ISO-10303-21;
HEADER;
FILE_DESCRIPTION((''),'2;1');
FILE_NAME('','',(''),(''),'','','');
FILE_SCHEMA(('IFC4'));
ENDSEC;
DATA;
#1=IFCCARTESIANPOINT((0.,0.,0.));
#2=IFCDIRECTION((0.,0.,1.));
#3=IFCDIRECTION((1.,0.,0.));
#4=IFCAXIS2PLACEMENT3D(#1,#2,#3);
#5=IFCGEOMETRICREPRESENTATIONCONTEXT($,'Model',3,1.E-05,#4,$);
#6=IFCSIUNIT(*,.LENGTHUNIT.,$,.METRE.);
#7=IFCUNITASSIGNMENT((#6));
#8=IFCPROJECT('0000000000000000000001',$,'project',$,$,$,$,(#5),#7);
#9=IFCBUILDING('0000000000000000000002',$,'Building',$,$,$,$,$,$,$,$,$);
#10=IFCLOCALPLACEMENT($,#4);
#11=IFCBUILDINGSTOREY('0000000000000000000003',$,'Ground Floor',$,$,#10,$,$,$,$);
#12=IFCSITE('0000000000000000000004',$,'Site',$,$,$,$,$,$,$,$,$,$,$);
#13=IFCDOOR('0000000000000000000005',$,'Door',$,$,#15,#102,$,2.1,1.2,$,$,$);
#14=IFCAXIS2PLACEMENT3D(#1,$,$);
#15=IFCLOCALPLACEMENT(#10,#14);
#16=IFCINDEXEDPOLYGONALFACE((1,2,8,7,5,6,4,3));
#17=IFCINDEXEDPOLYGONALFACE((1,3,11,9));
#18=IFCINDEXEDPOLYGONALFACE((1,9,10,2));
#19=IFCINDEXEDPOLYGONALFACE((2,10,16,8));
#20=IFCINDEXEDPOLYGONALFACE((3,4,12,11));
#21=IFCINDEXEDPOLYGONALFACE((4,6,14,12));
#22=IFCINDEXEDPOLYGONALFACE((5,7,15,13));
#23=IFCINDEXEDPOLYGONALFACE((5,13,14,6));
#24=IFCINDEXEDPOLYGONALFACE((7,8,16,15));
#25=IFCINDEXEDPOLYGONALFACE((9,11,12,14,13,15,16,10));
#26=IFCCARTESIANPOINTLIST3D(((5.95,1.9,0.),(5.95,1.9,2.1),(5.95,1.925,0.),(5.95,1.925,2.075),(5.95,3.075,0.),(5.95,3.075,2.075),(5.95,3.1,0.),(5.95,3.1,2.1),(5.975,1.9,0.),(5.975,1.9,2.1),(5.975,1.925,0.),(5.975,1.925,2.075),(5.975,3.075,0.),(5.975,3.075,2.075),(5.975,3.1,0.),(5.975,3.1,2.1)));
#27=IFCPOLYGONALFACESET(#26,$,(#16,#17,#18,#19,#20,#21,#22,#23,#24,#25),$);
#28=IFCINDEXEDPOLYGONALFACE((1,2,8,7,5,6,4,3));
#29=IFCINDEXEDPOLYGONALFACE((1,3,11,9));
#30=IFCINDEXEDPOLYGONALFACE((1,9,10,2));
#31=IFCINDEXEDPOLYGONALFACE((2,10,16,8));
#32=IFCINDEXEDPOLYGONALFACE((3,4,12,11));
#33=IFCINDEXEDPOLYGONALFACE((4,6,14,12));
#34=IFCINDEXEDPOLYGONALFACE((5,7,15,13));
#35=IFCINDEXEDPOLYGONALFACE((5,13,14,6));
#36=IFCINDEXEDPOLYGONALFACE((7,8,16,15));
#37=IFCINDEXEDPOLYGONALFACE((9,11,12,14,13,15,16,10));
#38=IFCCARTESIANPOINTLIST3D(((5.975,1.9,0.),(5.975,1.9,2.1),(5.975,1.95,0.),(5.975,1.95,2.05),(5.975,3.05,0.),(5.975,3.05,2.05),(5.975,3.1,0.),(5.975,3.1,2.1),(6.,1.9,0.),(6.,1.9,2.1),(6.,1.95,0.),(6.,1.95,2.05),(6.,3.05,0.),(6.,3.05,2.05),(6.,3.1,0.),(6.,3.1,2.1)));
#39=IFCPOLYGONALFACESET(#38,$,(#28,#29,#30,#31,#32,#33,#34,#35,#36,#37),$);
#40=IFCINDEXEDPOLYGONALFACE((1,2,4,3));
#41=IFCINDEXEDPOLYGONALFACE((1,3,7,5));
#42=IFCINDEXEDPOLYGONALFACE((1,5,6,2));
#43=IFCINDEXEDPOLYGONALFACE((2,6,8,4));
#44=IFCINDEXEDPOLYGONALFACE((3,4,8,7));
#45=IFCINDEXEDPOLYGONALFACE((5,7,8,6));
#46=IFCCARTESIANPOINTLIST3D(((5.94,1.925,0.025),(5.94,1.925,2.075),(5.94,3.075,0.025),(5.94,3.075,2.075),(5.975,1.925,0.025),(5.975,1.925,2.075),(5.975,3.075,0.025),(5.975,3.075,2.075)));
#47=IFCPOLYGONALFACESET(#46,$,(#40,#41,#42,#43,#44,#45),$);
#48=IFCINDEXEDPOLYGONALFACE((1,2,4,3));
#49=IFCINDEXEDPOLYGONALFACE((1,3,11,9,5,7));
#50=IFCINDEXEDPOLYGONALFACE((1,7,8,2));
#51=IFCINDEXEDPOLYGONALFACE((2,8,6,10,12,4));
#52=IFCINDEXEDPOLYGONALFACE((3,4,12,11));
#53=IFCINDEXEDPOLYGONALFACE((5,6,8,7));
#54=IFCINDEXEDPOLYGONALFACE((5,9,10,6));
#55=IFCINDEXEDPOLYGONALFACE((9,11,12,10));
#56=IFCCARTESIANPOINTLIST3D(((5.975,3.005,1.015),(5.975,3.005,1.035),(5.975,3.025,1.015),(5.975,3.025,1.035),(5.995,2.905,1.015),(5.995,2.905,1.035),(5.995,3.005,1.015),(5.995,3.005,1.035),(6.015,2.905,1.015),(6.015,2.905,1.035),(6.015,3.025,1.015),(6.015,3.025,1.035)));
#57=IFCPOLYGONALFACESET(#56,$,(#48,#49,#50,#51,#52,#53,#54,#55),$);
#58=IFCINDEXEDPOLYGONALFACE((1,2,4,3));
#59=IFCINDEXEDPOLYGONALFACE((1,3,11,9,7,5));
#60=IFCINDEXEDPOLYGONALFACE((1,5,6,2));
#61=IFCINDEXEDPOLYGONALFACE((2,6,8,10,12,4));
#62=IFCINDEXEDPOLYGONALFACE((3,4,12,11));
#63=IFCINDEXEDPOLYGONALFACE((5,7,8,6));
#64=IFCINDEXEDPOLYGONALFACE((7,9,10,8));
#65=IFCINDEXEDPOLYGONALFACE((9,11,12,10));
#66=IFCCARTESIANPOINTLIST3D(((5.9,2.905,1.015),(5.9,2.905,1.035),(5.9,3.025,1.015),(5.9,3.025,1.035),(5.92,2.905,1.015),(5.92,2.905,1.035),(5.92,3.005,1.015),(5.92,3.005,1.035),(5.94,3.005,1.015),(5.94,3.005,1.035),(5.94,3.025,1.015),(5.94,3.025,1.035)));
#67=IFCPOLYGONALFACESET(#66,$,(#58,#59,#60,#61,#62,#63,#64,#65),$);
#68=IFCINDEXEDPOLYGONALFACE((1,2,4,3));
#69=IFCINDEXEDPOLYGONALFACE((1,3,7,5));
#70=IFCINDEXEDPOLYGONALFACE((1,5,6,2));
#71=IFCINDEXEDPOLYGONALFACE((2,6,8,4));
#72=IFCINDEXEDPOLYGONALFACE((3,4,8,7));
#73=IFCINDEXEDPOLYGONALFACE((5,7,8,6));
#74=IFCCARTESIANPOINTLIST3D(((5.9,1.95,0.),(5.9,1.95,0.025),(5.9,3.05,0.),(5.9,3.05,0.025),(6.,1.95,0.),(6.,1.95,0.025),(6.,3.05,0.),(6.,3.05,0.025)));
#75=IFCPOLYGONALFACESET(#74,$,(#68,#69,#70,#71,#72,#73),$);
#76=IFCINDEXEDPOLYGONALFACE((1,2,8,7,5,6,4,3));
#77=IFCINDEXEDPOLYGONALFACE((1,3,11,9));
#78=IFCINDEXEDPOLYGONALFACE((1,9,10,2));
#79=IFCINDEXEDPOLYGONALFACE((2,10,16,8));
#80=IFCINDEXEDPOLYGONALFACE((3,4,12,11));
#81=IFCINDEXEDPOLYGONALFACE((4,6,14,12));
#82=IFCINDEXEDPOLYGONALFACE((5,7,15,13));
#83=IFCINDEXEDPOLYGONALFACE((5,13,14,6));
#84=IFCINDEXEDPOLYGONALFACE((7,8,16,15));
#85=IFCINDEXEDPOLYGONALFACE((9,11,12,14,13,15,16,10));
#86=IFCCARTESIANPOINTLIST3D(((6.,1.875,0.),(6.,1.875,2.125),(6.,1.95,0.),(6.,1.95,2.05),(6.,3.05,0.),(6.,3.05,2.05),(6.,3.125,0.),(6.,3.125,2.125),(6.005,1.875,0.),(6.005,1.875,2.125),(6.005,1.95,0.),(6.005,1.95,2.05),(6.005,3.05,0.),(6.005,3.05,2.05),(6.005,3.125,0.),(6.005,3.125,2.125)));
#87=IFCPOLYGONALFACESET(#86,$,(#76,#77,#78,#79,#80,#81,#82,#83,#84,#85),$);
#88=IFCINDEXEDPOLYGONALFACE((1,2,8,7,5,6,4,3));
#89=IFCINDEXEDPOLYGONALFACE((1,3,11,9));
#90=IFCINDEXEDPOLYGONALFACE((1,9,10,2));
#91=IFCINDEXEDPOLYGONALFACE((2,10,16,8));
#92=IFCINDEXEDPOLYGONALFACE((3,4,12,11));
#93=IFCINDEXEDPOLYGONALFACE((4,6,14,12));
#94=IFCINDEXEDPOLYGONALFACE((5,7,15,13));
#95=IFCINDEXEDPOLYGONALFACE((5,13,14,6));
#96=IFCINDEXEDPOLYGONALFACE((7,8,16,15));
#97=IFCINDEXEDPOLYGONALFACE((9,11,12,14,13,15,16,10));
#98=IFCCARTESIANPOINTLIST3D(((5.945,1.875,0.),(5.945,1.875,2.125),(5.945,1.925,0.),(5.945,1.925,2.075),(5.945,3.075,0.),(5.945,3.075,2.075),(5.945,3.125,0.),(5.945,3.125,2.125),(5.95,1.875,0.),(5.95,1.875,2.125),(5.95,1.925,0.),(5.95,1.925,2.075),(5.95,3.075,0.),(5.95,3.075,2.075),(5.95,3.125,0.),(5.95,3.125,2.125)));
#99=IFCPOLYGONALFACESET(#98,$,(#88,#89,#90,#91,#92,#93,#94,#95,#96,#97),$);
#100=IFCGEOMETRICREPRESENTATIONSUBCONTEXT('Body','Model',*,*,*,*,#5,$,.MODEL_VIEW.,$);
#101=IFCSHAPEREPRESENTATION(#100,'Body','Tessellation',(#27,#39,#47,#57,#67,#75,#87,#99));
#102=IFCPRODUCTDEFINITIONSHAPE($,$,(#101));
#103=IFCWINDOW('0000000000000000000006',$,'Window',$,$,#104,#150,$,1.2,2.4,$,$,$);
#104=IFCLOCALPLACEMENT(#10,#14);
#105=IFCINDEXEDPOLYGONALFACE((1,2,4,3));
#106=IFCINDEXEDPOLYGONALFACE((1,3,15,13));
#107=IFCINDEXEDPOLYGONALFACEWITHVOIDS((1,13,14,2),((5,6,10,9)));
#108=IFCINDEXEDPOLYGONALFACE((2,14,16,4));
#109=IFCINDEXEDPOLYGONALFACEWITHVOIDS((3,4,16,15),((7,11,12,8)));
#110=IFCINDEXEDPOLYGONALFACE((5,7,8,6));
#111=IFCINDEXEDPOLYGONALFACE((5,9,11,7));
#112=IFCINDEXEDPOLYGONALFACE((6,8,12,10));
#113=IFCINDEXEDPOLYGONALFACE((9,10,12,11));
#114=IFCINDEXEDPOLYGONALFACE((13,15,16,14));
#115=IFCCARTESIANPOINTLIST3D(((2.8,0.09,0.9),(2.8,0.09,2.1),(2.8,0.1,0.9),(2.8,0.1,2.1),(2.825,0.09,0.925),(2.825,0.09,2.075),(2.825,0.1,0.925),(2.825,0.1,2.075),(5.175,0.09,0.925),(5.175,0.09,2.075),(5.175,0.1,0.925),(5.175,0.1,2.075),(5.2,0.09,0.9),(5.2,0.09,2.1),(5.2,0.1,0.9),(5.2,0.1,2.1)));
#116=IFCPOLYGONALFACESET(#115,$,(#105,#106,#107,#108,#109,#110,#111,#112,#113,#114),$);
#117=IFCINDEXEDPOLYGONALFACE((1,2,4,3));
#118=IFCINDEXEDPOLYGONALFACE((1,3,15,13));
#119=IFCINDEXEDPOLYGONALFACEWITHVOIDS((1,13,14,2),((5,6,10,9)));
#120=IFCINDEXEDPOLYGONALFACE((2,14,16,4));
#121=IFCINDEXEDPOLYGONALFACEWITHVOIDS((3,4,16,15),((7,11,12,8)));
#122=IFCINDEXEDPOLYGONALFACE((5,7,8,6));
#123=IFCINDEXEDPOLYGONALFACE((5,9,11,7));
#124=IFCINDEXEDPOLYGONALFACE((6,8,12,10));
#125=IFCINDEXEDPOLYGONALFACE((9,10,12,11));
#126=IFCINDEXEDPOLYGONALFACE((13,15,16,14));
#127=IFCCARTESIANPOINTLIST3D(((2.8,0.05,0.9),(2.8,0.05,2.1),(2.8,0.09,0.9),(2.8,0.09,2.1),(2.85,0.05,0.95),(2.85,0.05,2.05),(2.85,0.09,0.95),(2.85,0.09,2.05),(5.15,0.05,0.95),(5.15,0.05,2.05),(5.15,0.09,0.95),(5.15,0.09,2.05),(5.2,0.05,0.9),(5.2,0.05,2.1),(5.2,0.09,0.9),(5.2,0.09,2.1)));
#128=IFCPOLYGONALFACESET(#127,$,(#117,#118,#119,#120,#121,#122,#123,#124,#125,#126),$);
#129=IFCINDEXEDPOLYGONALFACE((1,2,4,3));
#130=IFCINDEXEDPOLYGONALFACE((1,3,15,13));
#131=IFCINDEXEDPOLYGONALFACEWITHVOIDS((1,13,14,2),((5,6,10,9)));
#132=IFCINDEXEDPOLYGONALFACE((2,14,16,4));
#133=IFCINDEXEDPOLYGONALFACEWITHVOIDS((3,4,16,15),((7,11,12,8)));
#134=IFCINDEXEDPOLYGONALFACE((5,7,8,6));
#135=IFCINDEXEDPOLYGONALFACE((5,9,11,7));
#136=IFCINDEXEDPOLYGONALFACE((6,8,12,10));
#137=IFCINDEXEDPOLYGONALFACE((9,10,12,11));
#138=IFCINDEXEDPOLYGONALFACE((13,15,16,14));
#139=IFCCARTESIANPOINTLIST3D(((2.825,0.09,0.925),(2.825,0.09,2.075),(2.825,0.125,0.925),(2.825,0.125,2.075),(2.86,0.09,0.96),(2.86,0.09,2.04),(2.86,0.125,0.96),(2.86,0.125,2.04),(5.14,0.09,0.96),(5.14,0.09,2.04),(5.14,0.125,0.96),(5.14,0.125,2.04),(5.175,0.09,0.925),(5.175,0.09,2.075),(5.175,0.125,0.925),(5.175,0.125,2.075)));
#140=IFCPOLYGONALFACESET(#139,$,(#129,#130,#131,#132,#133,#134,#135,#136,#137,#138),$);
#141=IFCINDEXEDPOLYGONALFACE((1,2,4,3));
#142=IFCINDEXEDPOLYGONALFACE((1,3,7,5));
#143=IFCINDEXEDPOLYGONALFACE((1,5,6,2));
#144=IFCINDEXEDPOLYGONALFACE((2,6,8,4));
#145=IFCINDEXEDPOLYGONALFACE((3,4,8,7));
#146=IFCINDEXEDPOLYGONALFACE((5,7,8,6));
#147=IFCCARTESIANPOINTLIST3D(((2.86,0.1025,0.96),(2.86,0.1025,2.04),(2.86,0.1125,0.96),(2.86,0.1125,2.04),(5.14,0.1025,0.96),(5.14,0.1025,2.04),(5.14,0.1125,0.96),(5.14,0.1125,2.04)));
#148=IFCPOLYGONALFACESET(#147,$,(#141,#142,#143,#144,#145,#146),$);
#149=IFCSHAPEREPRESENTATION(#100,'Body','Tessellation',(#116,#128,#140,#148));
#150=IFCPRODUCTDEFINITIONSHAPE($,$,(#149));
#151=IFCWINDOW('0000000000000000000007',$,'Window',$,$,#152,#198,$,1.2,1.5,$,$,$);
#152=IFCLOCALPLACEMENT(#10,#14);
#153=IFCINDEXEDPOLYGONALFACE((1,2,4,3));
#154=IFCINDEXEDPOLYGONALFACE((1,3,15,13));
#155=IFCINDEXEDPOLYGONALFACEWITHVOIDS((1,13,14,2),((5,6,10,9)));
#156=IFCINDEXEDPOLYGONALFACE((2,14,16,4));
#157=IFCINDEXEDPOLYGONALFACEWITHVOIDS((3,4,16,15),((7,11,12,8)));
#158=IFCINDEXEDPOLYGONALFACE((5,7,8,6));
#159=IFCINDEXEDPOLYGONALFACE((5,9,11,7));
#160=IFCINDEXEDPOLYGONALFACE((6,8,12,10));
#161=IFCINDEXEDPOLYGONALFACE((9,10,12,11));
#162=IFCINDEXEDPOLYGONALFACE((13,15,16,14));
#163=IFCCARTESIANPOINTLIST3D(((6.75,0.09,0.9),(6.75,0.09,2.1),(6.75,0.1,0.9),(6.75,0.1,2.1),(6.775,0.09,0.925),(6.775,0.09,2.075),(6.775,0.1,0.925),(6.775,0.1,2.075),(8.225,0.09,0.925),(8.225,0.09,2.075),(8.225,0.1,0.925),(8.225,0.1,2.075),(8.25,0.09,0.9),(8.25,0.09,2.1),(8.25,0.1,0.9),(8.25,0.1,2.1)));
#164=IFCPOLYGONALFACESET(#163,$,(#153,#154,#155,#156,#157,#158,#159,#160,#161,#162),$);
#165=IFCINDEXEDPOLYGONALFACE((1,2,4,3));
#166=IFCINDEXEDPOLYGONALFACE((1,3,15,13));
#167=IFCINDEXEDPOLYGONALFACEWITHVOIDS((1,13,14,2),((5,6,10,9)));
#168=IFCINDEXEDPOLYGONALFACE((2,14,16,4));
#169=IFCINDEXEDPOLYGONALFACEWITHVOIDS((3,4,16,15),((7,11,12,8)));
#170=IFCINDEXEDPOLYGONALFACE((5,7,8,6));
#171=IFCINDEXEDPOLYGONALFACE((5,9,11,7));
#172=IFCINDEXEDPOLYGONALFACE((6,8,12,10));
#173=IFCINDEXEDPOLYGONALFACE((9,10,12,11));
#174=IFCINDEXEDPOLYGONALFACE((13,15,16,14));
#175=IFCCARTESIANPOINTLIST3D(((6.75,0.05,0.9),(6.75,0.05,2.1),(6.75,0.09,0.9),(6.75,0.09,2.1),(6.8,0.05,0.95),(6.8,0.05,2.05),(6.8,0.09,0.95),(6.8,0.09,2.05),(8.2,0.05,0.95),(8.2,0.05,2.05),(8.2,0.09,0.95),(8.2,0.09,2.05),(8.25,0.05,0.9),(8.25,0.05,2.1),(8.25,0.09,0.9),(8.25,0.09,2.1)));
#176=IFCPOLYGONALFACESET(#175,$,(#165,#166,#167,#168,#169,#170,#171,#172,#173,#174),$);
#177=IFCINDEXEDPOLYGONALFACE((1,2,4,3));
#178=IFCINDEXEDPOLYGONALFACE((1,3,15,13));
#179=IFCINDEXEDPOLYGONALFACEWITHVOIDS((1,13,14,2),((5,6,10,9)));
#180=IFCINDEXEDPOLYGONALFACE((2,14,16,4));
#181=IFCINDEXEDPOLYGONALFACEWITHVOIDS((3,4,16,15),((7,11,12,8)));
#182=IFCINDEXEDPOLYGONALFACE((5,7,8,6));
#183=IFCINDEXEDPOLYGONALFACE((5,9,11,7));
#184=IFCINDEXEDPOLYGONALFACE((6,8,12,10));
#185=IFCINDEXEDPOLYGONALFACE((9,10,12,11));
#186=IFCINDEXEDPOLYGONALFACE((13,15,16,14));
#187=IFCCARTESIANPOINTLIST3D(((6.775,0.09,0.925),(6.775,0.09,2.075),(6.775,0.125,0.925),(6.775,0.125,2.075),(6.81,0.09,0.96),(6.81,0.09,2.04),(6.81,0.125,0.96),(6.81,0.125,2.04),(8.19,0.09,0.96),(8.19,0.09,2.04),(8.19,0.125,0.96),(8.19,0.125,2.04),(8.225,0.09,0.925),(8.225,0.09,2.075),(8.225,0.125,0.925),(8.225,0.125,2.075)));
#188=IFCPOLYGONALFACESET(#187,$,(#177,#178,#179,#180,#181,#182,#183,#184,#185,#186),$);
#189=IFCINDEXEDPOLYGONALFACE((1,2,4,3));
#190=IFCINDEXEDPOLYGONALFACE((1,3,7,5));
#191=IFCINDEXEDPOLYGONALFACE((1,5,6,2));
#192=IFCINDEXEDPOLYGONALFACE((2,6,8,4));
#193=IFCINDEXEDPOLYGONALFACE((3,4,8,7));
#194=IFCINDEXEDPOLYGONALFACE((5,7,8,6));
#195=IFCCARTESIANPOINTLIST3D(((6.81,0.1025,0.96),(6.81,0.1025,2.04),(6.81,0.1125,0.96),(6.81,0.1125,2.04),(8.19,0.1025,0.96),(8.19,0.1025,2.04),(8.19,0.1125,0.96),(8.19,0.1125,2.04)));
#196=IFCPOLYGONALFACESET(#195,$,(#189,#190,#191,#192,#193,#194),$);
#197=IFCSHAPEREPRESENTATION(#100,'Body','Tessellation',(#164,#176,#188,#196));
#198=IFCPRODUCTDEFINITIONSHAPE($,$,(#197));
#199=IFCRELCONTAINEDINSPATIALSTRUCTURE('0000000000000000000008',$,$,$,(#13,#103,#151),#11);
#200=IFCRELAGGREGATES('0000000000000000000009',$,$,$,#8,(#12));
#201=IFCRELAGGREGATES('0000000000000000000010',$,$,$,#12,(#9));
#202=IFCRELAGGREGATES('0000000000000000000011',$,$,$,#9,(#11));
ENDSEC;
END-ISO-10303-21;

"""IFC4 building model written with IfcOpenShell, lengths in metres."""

from ifc_helpers import new_model, si_unit, frame, origin_with_axes, place, context, subcontext, project, spatial, line, indexed_curve, outline, extrude, element, save


model = new_model("IFC4")

# Units and contexts
model_context = context("Model", 3, precision=1e-05, world=origin_with_axes())
body_context = subcontext(model_context, "Body", "Model", "MODEL_VIEW")
ifc_project = project(units=[si_unit("LENGTHUNIT", "METRE")], contexts=[model_context])

# Site, building, storey
site = spatial("IfcSite", under=ifc_project, Name="Site")
building = spatial("IfcBuilding", under=site, Name="Building")
storey_placement = place(None, origin_with_axes())
storey = spatial("IfcBuildingStorey", under=building, at=storey_placement, Name="Ground Floor")

# Door
door_1_placement = place(storey_placement, frame((6.0, 1.9, 0.0), z_axis=(0.0, 0.0, 1.0), x_axis=(0.0, 1.0, 0.0)))
element("IfcDoor", 1, at=door_1_placement, inside=storey, Name="Door", OverallHeight=2.1, OverallWidth=1.2, context=body_context, shape_type="SweptSolid", body=[
    extrude(outline(indexed_curve([(0.0, 0.0), (0.0, 2.1), (1.2, 2.1), (1.2, 0.0), (1.175, 0.0), (1.175, 2.075), (0.025, 2.075), (0.025, 0.0)], segments=[line(1, 2, 3, 4, 5, 6, 7, 8, 1)])), frame((0.0, 0.025, 0.0), z_axis=(0.0, -1.0, 0.0), x_axis=(1.0, 0.0, 0.0)), (0.0, 0.0, -1.0), 0.025),
    extrude(outline(indexed_curve([(0.0, 0.0), (0.0, 2.1), (1.2, 2.1), (1.2, 0.0), (1.15, 0.0), (1.15, 2.05), (0.05, 2.05), (0.05, 0.0)], segments=[line(1, 2, 3, 4, 5, 6, 7, 8, 1)])), frame((0.0, 0.0, 0.0), z_axis=(0.0, -1.0, 0.0), x_axis=(1.0, 0.0, 0.0)), (0.0, 0.0, -1.0), 0.025),
    extrude(outline(indexed_curve([(0.0, 0.0), (1.15, 0.0), (1.15, 0.035), (0.0, 0.035)], segments=[line(1, 2, 3, 4, 1)])), frame((0.025, 0.025, 0.025), z_axis=(0.0, 0.0, 1.0), x_axis=(1.0, 0.0, 0.0)), (0.0, 0.0, 1.0), 2.05),
    extrude(outline(indexed_curve([(0.0, 0.0), (0.0, -0.04), (-0.12, -0.04), (-0.12, -0.02), (-0.02, -0.02), (-0.02, 0.0)], segments=[line(1, 2, 3, 4, 5, 6, 1)])), frame((1.125, 0.025, 1.015), z_axis=(0.0, 0.0, 1.0), x_axis=(1.0, 0.0, 0.0)), (0.0, 0.0, 1.0), 0.02),
    extrude(outline(indexed_curve([(0.0, 0.0), (0.0, 0.04), (-0.12, 0.04), (-0.12, 0.02), (-0.02, 0.02), (-0.02, 0.0)], segments=[line(1, 2, 3, 4, 5, 6, 1)])), frame((1.125, 0.06, 1.015), z_axis=(0.0, 0.0, 1.0), x_axis=(1.0, 0.0, 0.0)), (0.0, 0.0, 1.0), 0.02),
    extrude(outline(indexed_curve([(0.0, 0.0), (1.1, 0.0), (1.1, 0.1), (0.0, 0.1)], segments=[line(1, 2, 3, 4, 1)])), frame((0.05, 0.0, 0.0), z_axis=(0.0, 0.0, 1.0), x_axis=(1.0, 0.0, 0.0)), (0.0, 0.0, 1.0), 0.025),
    extrude(outline(indexed_curve([(0.0, 0.0), (0.0, 2.125), (1.25, 2.125), (1.25, 0.0), (1.175, 0.0), (1.175, 2.05), (0.075, 2.05), (0.075, 0.0)], segments=[line(1, 2, 3, 4, 5, 6, 7, 8, 1)])), frame((-0.025, -0.005, 0.0), z_axis=(0.0, -1.0, 0.0), x_axis=(1.0, 0.0, 0.0)), (0.0, 0.0, -1.0), 0.005),
    extrude(outline(indexed_curve([(0.0, 0.0), (0.0, 2.125), (1.25, 2.125), (1.25, 0.0), (1.2, 0.0), (1.2, 2.075), (0.05, 2.075), (0.05, 0.0)], segments=[line(1, 2, 3, 4, 5, 6, 7, 8, 1)])), frame((-0.025, 0.05, 0.0), z_axis=(0.0, -1.0, 0.0), x_axis=(1.0, 0.0, 0.0)), (0.0, 0.0, -1.0), 0.005),
])

# Windows
window_1_placement = place(storey_placement, frame((2.8, 0.0, 0.9), z_axis=(0.0, 0.0, 1.0), x_axis=(1.0, 0.0, 0.0)))
element("IfcWindow", 2, at=window_1_placement, inside=storey, Name="Window", OverallHeight=1.2, OverallWidth=2.4, context=body_context, shape_type="SweptSolid", body=[
    extrude(outline(indexed_curve([(0.0, 0.0), (2.4, 0.0), (2.4, 1.2), (0.0, 1.2)], segments=[line(1, 2, 3, 4, 1)]), holes=[indexed_curve([(0.025, 0.025), (2.375, 0.025), (2.375, 1.175), (0.025, 1.175)], segments=[line(1, 2, 3, 4, 1)])]), frame((0.0, 0.09, 0.0), z_axis=(0.0, -1.0, 0.0), x_axis=(1.0, 0.0, 0.0)), (0.0, 0.0, -1.0), 0.01),
    extrude(outline(indexed_curve([(0.0, 0.0), (2.4, 0.0), (2.4, 1.2), (0.0, 1.2)], segments=[line(1, 2, 3, 4, 1)]), holes=[indexed_curve([(0.05, 0.05), (2.35, 0.05), (2.35, 1.15), (0.05, 1.15)], segments=[line(1, 2, 3, 4, 1)])]), frame((0.0, 0.05, 0.0), z_axis=(0.0, -1.0, 0.0), x_axis=(1.0, 0.0, 0.0)), (0.0, 0.0, -1.0), 0.04),
    extrude(outline(indexed_curve([(0.0, 0.0), (2.35, 0.0), (2.35, 1.15), (0.0, 1.15)], segments=[line(1, 2, 3, 4, 1)]), holes=[indexed_curve([(0.035, 0.035), (2.315, 0.035), (2.315, 1.115), (0.035, 1.115)], segments=[line(1, 2, 3, 4, 1)])]), frame((0.025, 0.09, 0.025), z_axis=(0.0, -1.0, 0.0), x_axis=(1.0, 0.0, 0.0)), (0.0, 0.0, -1.0), 0.035),
    extrude(outline(indexed_curve([(0.035, 0.035), (2.315, 0.035), (2.315, 1.115), (0.035, 1.115)], segments=[line(1, 2, 3, 4, 1)])), frame((0.025, 0.1025, 0.025), z_axis=(0.0, -1.0, 0.0), x_axis=(1.0, 0.0, 0.0)), (0.0, 0.0, -1.0), 0.01),
])
for number, where, z_axis, x_axis, name in (
    (3, (6.75, 0.0, 0.9), (0.0, 0.0, 1.0), (1.0, 0.0, 0.0), "Window"),
):
    element("IfcWindow", number, at=place(storey_placement, frame(where, z_axis=z_axis, x_axis=x_axis)), inside=storey, Name=name, OverallHeight=1.2, OverallWidth=1.5, context=body_context, shape_type="SweptSolid", body=[
        extrude(outline(indexed_curve([(0.0, 0.0), (1.5, 0.0), (1.5, 1.2), (0.0, 1.2)], segments=[line(1, 2, 3, 4, 1)]), holes=[indexed_curve([(0.025, 0.025), (1.475, 0.025), (1.475, 1.175), (0.025, 1.175)], segments=[line(1, 2, 3, 4, 1)])]), frame((0.0, 0.09, 0.0), z_axis=(0.0, -1.0, 0.0), x_axis=(1.0, 0.0, 0.0)), (0.0, 0.0, -1.0), 0.01),
        extrude(outline(indexed_curve([(0.0, 0.0), (1.5, 0.0), (1.5, 1.2), (0.0, 1.2)], segments=[line(1, 2, 3, 4, 1)]), holes=[indexed_curve([(0.05, 0.05), (1.45, 0.05), (1.45, 1.15), (0.05, 1.15)], segments=[line(1, 2, 3, 4, 1)])]), frame((0.0, 0.05, 0.0), z_axis=(0.0, -1.0, 0.0), x_axis=(1.0, 0.0, 0.0)), (0.0, 0.0, -1.0), 0.04),
        extrude(outline(indexed_curve([(0.0, 0.0), (1.45, 0.0), (1.45, 1.15), (0.0, 1.15)], segments=[line(1, 2, 3, 4, 1)]), holes=[indexed_curve([(0.035, 0.035), (1.415, 0.035), (1.415, 1.115), (0.035, 1.115)], segments=[line(1, 2, 3, 4, 1)])]), frame((0.025, 0.09, 0.025), z_axis=(0.0, -1.0, 0.0), x_axis=(1.0, 0.0, 0.0)), (0.0, 0.0, -1.0), 0.035),
        extrude(outline(indexed_curve([(0.035, 0.035), (1.415, 0.035), (1.415, 1.115), (0.035, 1.115)], segments=[line(1, 2, 3, 4, 1)])), frame((0.025, 0.1025, 0.025), z_axis=(0.0, -1.0, 0.0), x_axis=(1.0, 0.0, 0.0)), (0.0, 0.0, -1.0), 0.01),
    ])

save(model, "model.ifc")
